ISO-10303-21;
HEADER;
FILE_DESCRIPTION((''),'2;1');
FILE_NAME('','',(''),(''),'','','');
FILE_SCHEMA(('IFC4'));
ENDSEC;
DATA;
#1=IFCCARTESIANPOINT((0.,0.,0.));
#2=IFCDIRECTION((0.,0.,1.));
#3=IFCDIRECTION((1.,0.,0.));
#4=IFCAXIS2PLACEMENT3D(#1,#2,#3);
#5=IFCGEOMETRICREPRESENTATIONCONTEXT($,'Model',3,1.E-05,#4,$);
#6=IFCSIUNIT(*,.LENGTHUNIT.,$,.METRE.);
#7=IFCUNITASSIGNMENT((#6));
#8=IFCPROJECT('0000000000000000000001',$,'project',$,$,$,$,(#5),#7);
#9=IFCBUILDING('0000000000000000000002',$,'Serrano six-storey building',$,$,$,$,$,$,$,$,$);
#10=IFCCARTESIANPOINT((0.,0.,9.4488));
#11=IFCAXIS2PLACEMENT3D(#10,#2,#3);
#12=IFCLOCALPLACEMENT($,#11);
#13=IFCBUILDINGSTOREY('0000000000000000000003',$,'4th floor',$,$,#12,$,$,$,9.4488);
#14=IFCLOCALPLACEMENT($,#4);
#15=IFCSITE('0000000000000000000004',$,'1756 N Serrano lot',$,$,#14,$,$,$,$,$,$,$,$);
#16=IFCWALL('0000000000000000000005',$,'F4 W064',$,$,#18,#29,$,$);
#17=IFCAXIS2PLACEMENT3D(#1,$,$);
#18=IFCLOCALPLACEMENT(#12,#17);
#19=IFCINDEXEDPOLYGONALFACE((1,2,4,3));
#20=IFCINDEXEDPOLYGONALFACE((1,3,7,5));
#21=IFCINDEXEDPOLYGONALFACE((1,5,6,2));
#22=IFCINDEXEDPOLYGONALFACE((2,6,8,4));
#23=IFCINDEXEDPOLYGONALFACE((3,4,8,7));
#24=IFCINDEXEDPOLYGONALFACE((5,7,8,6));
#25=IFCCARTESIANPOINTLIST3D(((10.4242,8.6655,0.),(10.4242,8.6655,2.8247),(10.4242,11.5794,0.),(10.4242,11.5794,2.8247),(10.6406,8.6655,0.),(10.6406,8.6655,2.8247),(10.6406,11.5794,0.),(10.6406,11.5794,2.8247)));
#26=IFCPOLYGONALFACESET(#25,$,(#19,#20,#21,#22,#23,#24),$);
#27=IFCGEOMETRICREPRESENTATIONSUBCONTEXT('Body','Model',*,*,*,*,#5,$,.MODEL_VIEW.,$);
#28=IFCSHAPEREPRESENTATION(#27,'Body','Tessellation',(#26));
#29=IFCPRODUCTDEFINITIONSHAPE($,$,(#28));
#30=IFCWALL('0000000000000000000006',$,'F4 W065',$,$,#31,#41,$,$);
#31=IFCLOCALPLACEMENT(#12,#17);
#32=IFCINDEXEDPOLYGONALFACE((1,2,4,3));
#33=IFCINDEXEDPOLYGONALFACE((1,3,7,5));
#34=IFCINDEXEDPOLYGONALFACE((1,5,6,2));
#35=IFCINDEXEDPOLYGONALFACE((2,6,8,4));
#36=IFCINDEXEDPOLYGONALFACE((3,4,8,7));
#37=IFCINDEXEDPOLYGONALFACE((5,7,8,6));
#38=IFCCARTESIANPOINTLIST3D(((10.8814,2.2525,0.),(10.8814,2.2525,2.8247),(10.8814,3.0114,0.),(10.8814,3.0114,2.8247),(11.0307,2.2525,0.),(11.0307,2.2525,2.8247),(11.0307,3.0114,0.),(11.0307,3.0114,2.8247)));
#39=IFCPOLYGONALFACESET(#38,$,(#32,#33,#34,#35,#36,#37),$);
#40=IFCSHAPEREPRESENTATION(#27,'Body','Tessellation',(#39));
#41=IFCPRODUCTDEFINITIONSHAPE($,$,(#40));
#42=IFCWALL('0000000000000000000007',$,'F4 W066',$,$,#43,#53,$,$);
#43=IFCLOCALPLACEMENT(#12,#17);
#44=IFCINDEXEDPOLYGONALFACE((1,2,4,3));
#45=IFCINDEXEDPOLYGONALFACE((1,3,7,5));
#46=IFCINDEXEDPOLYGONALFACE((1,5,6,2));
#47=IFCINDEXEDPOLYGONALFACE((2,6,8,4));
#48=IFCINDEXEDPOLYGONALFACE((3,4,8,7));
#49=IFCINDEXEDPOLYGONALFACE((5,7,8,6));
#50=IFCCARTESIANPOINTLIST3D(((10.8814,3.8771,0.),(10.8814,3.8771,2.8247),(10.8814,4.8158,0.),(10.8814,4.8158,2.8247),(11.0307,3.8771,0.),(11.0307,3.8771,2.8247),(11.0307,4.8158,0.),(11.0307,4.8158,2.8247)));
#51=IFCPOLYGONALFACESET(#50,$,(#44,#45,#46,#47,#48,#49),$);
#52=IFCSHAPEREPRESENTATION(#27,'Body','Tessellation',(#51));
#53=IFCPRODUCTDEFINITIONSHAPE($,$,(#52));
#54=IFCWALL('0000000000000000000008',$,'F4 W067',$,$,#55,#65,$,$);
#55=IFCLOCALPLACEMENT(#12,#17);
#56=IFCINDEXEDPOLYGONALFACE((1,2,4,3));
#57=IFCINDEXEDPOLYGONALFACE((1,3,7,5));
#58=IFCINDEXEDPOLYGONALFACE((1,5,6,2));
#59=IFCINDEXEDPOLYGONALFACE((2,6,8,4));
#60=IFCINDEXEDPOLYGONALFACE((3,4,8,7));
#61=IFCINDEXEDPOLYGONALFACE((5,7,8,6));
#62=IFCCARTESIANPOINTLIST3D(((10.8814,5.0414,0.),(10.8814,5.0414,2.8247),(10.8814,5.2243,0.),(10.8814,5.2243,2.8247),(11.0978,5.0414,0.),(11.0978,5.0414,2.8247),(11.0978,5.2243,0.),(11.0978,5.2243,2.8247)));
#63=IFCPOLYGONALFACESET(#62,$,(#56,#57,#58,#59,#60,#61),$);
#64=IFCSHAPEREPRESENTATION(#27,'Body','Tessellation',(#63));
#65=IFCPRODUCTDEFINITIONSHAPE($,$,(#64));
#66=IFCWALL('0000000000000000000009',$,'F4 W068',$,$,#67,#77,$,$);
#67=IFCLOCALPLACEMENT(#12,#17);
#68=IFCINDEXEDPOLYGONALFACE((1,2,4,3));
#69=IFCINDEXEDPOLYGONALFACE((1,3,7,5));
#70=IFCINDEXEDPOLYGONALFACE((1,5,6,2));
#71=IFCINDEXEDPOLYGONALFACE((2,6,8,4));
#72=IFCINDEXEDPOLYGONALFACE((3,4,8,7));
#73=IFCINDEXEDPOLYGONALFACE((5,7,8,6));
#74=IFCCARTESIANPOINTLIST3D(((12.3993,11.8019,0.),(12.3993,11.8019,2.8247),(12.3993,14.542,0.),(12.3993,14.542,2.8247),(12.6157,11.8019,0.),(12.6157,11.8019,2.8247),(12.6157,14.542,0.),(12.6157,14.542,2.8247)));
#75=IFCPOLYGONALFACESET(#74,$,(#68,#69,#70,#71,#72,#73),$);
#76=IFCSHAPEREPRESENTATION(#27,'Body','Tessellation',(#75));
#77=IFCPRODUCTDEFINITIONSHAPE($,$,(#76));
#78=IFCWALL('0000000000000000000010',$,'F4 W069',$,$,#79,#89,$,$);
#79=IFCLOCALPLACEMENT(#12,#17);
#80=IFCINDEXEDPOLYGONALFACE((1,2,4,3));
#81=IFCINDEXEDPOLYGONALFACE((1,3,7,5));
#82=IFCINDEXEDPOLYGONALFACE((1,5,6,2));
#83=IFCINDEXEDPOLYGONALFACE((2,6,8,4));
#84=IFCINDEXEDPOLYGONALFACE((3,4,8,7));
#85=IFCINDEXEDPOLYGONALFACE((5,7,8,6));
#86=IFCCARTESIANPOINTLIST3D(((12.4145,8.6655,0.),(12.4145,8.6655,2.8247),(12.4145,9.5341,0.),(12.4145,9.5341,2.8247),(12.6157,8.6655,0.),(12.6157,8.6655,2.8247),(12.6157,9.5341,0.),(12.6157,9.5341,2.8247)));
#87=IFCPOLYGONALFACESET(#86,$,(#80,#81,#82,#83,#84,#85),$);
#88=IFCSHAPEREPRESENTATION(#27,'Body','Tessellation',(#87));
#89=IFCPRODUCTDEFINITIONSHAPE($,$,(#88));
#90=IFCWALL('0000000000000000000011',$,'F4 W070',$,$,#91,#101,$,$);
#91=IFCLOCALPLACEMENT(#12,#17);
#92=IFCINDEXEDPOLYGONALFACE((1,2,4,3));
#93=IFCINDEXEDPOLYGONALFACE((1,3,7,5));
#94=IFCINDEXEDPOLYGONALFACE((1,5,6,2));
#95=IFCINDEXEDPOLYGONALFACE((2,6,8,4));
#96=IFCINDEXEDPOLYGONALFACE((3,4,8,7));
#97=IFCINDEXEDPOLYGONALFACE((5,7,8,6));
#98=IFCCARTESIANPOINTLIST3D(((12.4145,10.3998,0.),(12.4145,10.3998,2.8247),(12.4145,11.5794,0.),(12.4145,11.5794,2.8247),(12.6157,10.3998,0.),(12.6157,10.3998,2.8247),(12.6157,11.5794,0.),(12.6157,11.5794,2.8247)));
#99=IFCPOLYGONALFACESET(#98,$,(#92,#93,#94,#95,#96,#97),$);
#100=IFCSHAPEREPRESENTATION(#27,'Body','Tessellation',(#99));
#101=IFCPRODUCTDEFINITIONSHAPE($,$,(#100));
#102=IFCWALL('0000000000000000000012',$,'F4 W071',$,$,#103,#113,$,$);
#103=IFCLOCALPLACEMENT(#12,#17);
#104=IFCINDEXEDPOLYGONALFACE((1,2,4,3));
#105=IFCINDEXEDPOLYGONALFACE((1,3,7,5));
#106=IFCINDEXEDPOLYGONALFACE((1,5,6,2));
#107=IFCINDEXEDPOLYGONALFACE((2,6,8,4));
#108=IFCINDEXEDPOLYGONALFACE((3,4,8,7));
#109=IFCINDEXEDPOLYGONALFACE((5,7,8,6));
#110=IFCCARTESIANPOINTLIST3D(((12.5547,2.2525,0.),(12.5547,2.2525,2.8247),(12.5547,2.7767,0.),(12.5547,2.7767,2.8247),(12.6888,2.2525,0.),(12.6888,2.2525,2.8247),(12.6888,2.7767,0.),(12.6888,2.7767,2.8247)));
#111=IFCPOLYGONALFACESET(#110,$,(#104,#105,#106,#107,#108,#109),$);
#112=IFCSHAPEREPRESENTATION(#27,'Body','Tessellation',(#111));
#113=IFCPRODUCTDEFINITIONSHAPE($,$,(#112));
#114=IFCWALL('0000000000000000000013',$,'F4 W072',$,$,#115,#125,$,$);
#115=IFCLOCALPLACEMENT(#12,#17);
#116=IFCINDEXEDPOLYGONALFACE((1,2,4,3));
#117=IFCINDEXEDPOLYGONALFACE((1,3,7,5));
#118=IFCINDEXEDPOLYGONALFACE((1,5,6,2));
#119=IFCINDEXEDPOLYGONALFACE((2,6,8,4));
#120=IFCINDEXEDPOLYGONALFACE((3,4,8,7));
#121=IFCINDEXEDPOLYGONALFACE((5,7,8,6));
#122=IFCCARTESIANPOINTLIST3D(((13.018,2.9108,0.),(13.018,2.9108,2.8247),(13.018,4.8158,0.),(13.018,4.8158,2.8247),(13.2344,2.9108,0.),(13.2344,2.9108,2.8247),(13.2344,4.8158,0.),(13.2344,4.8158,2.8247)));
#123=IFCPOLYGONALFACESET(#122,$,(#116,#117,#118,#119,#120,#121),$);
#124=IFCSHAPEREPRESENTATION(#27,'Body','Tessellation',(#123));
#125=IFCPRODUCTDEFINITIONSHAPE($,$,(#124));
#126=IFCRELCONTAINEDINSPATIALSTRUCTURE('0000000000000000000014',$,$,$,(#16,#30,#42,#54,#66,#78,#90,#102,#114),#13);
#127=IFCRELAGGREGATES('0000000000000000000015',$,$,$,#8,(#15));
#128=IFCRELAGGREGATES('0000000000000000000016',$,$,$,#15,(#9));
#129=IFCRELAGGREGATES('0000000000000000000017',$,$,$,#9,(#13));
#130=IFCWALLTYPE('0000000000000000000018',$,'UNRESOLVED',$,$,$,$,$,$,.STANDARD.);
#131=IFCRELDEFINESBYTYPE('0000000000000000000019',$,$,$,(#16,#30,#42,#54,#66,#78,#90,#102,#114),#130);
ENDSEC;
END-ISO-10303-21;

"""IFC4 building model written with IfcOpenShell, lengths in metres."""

from ifc_helpers import new_model, si_unit, frame, origin_with_axes, place, context, subcontext, project, spatial, polyline, outline, extrude, type_object, element, save


model = new_model("IFC4")

# Units and contexts
model_context = context("Model", 3, precision=1e-05, world=origin_with_axes())
body_context = subcontext(model_context, "Body", "Model", "MODEL_VIEW")
ifc_project = project(units=[si_unit("LENGTHUNIT", "METRE")], contexts=[model_context])

# Site, building, storey
site_placement = place(None, origin_with_axes())
site = spatial("IfcSite", under=ifc_project, at=site_placement, Name="1756 N Serrano lot")
building = spatial("IfcBuilding", under=site, Name="Serrano six-storey building")
storey_placement = place(None, frame((0.0, 0.0, 9.4488), z_axis=(0.0, 0.0, 1.0), x_axis=(1.0, 0.0, 0.0)))
storey = spatial("IfcBuildingStorey", under=building, at=storey_placement, Name="4th floor", Elevation=9.4488)

# Walls
wall_type = type_object("IfcWallType", Name="UNRESOLVED", PredefinedType="STANDARD")
wall_1_placement = place(storey_placement, frame((0.0, 0.0, -9.4488), z_axis=(0.0, 0.0, 1.0), x_axis=(1.0, 0.0, 0.0)))
element("IfcWall", 1, at=wall_1_placement, inside=storey, type_object=wall_type, Name="F4 W064", context=body_context, shape_type="SweptSolid", body=[
    extrude(outline(polyline([(10.4242, 11.5794), (10.6406, 11.5794), (10.6406, 8.6655), (10.4242, 8.6655), (10.4242, 11.5794)])), frame((0.0, 0.0, 9.4488)), (0.0, 0.0, 1.0), 2.8247),
])
wall_2_placement = place(storey_placement, frame((0.0, 0.0, -9.4488), z_axis=(0.0, 0.0, 1.0), x_axis=(1.0, 0.0, 0.0)))
element("IfcWall", 2, at=wall_2_placement, inside=storey, type_object=wall_type, Name="F4 W065", context=body_context, shape_type="SweptSolid", body=[
    extrude(outline(polyline([(10.8814, 3.0114), (11.0307, 3.0114), (11.0307, 2.2525), (10.8814, 2.2525), (10.8814, 3.0114)])), frame((0.0, 0.0, 9.4488)), (0.0, 0.0, 1.0), 2.8247),
])
wall_3_placement = place(storey_placement, frame((0.0, 0.0, -9.4488), z_axis=(0.0, 0.0, 1.0), x_axis=(1.0, 0.0, 0.0)))
element("IfcWall", 3, at=wall_3_placement, inside=storey, type_object=wall_type, Name="F4 W066", context=body_context, shape_type="SweptSolid", body=[
    extrude(outline(polyline([(10.8814, 4.8158), (11.0307, 4.8158), (11.0307, 3.8771), (10.8814, 3.8771), (10.8814, 4.8158)])), frame((0.0, 0.0, 9.4488)), (0.0, 0.0, 1.0), 2.8247),
])
wall_4_placement = place(storey_placement, frame((0.0, 0.0, -9.4488), z_axis=(0.0, 0.0, 1.0), x_axis=(1.0, 0.0, 0.0)))
element("IfcWall", 4, at=wall_4_placement, inside=storey, type_object=wall_type, Name="F4 W067", context=body_context, shape_type="SweptSolid", body=[
    extrude(outline(polyline([(10.8814, 5.2243), (11.0978, 5.2243), (11.0978, 5.0414), (10.8814, 5.0414), (10.8814, 5.2243)])), frame((0.0, 0.0, 9.4488)), (0.0, 0.0, 1.0), 2.8247),
])
wall_5_placement = place(storey_placement, frame((0.0, 0.0, -9.4488), z_axis=(0.0, 0.0, 1.0), x_axis=(1.0, 0.0, 0.0)))
element("IfcWall", 5, at=wall_5_placement, inside=storey, type_object=wall_type, Name="F4 W068", context=body_context, shape_type="SweptSolid", body=[
    extrude(outline(polyline([(12.3993, 14.542), (12.6157, 14.542), (12.6157, 11.8019), (12.3993, 11.8019), (12.3993, 14.542)])), frame((0.0, 0.0, 9.4488)), (0.0, 0.0, 1.0), 2.8247),
])
wall_6_placement = place(storey_placement, frame((0.0, 0.0, -9.4488), z_axis=(0.0, 0.0, 1.0), x_axis=(1.0, 0.0, 0.0)))
element("IfcWall", 6, at=wall_6_placement, inside=storey, type_object=wall_type, Name="F4 W069", context=body_context, shape_type="SweptSolid", body=[
    extrude(outline(polyline([(12.4145, 9.5341), (12.6157, 9.5341), (12.6157, 8.6655), (12.4145, 8.6655), (12.4145, 9.5341)])), frame((0.0, 0.0, 9.4488)), (0.0, 0.0, 1.0), 2.8247),
])
wall_7_placement = place(storey_placement, frame((0.0, 0.0, -9.4488), z_axis=(0.0, 0.0, 1.0), x_axis=(1.0, 0.0, 0.0)))
element("IfcWall", 7, at=wall_7_placement, inside=storey, type_object=wall_type, Name="F4 W070", context=body_context, shape_type="SweptSolid", body=[
    extrude(outline(polyline([(12.4145, 11.5794), (12.6157, 11.5794), (12.6157, 10.3998), (12.4145, 10.3998), (12.4145, 11.5794)])), frame((0.0, 0.0, 9.4488)), (0.0, 0.0, 1.0), 2.8247),
])
wall_8_placement = place(storey_placement, frame((0.0, 0.0, -9.4488), z_axis=(0.0, 0.0, 1.0), x_axis=(1.0, 0.0, 0.0)))
element("IfcWall", 8, at=wall_8_placement, inside=storey, type_object=wall_type, Name="F4 W071", context=body_context, shape_type="SweptSolid", body=[
    extrude(outline(polyline([(12.5547, 2.7767), (12.6888, 2.7767), (12.6888, 2.2525), (12.5547, 2.2525), (12.5547, 2.7767)])), frame((0.0, 0.0, 9.4488)), (0.0, 0.0, 1.0), 2.8247),
])
wall_9_placement = place(storey_placement, frame((0.0, 0.0, -9.4488), z_axis=(0.0, 0.0, 1.0), x_axis=(1.0, 0.0, 0.0)))
element("IfcWall", 9, at=wall_9_placement, inside=storey, type_object=wall_type, Name="F4 W072", context=body_context, shape_type="SweptSolid", body=[
    extrude(outline(polyline([(13.018, 4.8158), (13.2344, 4.8158), (13.2344, 2.9108), (13.018, 2.9108), (13.018, 4.8158)])), frame((0.0, 0.0, 9.4488)), (0.0, 0.0, 1.0), 2.8247),
])

save(model, "model.ifc")
